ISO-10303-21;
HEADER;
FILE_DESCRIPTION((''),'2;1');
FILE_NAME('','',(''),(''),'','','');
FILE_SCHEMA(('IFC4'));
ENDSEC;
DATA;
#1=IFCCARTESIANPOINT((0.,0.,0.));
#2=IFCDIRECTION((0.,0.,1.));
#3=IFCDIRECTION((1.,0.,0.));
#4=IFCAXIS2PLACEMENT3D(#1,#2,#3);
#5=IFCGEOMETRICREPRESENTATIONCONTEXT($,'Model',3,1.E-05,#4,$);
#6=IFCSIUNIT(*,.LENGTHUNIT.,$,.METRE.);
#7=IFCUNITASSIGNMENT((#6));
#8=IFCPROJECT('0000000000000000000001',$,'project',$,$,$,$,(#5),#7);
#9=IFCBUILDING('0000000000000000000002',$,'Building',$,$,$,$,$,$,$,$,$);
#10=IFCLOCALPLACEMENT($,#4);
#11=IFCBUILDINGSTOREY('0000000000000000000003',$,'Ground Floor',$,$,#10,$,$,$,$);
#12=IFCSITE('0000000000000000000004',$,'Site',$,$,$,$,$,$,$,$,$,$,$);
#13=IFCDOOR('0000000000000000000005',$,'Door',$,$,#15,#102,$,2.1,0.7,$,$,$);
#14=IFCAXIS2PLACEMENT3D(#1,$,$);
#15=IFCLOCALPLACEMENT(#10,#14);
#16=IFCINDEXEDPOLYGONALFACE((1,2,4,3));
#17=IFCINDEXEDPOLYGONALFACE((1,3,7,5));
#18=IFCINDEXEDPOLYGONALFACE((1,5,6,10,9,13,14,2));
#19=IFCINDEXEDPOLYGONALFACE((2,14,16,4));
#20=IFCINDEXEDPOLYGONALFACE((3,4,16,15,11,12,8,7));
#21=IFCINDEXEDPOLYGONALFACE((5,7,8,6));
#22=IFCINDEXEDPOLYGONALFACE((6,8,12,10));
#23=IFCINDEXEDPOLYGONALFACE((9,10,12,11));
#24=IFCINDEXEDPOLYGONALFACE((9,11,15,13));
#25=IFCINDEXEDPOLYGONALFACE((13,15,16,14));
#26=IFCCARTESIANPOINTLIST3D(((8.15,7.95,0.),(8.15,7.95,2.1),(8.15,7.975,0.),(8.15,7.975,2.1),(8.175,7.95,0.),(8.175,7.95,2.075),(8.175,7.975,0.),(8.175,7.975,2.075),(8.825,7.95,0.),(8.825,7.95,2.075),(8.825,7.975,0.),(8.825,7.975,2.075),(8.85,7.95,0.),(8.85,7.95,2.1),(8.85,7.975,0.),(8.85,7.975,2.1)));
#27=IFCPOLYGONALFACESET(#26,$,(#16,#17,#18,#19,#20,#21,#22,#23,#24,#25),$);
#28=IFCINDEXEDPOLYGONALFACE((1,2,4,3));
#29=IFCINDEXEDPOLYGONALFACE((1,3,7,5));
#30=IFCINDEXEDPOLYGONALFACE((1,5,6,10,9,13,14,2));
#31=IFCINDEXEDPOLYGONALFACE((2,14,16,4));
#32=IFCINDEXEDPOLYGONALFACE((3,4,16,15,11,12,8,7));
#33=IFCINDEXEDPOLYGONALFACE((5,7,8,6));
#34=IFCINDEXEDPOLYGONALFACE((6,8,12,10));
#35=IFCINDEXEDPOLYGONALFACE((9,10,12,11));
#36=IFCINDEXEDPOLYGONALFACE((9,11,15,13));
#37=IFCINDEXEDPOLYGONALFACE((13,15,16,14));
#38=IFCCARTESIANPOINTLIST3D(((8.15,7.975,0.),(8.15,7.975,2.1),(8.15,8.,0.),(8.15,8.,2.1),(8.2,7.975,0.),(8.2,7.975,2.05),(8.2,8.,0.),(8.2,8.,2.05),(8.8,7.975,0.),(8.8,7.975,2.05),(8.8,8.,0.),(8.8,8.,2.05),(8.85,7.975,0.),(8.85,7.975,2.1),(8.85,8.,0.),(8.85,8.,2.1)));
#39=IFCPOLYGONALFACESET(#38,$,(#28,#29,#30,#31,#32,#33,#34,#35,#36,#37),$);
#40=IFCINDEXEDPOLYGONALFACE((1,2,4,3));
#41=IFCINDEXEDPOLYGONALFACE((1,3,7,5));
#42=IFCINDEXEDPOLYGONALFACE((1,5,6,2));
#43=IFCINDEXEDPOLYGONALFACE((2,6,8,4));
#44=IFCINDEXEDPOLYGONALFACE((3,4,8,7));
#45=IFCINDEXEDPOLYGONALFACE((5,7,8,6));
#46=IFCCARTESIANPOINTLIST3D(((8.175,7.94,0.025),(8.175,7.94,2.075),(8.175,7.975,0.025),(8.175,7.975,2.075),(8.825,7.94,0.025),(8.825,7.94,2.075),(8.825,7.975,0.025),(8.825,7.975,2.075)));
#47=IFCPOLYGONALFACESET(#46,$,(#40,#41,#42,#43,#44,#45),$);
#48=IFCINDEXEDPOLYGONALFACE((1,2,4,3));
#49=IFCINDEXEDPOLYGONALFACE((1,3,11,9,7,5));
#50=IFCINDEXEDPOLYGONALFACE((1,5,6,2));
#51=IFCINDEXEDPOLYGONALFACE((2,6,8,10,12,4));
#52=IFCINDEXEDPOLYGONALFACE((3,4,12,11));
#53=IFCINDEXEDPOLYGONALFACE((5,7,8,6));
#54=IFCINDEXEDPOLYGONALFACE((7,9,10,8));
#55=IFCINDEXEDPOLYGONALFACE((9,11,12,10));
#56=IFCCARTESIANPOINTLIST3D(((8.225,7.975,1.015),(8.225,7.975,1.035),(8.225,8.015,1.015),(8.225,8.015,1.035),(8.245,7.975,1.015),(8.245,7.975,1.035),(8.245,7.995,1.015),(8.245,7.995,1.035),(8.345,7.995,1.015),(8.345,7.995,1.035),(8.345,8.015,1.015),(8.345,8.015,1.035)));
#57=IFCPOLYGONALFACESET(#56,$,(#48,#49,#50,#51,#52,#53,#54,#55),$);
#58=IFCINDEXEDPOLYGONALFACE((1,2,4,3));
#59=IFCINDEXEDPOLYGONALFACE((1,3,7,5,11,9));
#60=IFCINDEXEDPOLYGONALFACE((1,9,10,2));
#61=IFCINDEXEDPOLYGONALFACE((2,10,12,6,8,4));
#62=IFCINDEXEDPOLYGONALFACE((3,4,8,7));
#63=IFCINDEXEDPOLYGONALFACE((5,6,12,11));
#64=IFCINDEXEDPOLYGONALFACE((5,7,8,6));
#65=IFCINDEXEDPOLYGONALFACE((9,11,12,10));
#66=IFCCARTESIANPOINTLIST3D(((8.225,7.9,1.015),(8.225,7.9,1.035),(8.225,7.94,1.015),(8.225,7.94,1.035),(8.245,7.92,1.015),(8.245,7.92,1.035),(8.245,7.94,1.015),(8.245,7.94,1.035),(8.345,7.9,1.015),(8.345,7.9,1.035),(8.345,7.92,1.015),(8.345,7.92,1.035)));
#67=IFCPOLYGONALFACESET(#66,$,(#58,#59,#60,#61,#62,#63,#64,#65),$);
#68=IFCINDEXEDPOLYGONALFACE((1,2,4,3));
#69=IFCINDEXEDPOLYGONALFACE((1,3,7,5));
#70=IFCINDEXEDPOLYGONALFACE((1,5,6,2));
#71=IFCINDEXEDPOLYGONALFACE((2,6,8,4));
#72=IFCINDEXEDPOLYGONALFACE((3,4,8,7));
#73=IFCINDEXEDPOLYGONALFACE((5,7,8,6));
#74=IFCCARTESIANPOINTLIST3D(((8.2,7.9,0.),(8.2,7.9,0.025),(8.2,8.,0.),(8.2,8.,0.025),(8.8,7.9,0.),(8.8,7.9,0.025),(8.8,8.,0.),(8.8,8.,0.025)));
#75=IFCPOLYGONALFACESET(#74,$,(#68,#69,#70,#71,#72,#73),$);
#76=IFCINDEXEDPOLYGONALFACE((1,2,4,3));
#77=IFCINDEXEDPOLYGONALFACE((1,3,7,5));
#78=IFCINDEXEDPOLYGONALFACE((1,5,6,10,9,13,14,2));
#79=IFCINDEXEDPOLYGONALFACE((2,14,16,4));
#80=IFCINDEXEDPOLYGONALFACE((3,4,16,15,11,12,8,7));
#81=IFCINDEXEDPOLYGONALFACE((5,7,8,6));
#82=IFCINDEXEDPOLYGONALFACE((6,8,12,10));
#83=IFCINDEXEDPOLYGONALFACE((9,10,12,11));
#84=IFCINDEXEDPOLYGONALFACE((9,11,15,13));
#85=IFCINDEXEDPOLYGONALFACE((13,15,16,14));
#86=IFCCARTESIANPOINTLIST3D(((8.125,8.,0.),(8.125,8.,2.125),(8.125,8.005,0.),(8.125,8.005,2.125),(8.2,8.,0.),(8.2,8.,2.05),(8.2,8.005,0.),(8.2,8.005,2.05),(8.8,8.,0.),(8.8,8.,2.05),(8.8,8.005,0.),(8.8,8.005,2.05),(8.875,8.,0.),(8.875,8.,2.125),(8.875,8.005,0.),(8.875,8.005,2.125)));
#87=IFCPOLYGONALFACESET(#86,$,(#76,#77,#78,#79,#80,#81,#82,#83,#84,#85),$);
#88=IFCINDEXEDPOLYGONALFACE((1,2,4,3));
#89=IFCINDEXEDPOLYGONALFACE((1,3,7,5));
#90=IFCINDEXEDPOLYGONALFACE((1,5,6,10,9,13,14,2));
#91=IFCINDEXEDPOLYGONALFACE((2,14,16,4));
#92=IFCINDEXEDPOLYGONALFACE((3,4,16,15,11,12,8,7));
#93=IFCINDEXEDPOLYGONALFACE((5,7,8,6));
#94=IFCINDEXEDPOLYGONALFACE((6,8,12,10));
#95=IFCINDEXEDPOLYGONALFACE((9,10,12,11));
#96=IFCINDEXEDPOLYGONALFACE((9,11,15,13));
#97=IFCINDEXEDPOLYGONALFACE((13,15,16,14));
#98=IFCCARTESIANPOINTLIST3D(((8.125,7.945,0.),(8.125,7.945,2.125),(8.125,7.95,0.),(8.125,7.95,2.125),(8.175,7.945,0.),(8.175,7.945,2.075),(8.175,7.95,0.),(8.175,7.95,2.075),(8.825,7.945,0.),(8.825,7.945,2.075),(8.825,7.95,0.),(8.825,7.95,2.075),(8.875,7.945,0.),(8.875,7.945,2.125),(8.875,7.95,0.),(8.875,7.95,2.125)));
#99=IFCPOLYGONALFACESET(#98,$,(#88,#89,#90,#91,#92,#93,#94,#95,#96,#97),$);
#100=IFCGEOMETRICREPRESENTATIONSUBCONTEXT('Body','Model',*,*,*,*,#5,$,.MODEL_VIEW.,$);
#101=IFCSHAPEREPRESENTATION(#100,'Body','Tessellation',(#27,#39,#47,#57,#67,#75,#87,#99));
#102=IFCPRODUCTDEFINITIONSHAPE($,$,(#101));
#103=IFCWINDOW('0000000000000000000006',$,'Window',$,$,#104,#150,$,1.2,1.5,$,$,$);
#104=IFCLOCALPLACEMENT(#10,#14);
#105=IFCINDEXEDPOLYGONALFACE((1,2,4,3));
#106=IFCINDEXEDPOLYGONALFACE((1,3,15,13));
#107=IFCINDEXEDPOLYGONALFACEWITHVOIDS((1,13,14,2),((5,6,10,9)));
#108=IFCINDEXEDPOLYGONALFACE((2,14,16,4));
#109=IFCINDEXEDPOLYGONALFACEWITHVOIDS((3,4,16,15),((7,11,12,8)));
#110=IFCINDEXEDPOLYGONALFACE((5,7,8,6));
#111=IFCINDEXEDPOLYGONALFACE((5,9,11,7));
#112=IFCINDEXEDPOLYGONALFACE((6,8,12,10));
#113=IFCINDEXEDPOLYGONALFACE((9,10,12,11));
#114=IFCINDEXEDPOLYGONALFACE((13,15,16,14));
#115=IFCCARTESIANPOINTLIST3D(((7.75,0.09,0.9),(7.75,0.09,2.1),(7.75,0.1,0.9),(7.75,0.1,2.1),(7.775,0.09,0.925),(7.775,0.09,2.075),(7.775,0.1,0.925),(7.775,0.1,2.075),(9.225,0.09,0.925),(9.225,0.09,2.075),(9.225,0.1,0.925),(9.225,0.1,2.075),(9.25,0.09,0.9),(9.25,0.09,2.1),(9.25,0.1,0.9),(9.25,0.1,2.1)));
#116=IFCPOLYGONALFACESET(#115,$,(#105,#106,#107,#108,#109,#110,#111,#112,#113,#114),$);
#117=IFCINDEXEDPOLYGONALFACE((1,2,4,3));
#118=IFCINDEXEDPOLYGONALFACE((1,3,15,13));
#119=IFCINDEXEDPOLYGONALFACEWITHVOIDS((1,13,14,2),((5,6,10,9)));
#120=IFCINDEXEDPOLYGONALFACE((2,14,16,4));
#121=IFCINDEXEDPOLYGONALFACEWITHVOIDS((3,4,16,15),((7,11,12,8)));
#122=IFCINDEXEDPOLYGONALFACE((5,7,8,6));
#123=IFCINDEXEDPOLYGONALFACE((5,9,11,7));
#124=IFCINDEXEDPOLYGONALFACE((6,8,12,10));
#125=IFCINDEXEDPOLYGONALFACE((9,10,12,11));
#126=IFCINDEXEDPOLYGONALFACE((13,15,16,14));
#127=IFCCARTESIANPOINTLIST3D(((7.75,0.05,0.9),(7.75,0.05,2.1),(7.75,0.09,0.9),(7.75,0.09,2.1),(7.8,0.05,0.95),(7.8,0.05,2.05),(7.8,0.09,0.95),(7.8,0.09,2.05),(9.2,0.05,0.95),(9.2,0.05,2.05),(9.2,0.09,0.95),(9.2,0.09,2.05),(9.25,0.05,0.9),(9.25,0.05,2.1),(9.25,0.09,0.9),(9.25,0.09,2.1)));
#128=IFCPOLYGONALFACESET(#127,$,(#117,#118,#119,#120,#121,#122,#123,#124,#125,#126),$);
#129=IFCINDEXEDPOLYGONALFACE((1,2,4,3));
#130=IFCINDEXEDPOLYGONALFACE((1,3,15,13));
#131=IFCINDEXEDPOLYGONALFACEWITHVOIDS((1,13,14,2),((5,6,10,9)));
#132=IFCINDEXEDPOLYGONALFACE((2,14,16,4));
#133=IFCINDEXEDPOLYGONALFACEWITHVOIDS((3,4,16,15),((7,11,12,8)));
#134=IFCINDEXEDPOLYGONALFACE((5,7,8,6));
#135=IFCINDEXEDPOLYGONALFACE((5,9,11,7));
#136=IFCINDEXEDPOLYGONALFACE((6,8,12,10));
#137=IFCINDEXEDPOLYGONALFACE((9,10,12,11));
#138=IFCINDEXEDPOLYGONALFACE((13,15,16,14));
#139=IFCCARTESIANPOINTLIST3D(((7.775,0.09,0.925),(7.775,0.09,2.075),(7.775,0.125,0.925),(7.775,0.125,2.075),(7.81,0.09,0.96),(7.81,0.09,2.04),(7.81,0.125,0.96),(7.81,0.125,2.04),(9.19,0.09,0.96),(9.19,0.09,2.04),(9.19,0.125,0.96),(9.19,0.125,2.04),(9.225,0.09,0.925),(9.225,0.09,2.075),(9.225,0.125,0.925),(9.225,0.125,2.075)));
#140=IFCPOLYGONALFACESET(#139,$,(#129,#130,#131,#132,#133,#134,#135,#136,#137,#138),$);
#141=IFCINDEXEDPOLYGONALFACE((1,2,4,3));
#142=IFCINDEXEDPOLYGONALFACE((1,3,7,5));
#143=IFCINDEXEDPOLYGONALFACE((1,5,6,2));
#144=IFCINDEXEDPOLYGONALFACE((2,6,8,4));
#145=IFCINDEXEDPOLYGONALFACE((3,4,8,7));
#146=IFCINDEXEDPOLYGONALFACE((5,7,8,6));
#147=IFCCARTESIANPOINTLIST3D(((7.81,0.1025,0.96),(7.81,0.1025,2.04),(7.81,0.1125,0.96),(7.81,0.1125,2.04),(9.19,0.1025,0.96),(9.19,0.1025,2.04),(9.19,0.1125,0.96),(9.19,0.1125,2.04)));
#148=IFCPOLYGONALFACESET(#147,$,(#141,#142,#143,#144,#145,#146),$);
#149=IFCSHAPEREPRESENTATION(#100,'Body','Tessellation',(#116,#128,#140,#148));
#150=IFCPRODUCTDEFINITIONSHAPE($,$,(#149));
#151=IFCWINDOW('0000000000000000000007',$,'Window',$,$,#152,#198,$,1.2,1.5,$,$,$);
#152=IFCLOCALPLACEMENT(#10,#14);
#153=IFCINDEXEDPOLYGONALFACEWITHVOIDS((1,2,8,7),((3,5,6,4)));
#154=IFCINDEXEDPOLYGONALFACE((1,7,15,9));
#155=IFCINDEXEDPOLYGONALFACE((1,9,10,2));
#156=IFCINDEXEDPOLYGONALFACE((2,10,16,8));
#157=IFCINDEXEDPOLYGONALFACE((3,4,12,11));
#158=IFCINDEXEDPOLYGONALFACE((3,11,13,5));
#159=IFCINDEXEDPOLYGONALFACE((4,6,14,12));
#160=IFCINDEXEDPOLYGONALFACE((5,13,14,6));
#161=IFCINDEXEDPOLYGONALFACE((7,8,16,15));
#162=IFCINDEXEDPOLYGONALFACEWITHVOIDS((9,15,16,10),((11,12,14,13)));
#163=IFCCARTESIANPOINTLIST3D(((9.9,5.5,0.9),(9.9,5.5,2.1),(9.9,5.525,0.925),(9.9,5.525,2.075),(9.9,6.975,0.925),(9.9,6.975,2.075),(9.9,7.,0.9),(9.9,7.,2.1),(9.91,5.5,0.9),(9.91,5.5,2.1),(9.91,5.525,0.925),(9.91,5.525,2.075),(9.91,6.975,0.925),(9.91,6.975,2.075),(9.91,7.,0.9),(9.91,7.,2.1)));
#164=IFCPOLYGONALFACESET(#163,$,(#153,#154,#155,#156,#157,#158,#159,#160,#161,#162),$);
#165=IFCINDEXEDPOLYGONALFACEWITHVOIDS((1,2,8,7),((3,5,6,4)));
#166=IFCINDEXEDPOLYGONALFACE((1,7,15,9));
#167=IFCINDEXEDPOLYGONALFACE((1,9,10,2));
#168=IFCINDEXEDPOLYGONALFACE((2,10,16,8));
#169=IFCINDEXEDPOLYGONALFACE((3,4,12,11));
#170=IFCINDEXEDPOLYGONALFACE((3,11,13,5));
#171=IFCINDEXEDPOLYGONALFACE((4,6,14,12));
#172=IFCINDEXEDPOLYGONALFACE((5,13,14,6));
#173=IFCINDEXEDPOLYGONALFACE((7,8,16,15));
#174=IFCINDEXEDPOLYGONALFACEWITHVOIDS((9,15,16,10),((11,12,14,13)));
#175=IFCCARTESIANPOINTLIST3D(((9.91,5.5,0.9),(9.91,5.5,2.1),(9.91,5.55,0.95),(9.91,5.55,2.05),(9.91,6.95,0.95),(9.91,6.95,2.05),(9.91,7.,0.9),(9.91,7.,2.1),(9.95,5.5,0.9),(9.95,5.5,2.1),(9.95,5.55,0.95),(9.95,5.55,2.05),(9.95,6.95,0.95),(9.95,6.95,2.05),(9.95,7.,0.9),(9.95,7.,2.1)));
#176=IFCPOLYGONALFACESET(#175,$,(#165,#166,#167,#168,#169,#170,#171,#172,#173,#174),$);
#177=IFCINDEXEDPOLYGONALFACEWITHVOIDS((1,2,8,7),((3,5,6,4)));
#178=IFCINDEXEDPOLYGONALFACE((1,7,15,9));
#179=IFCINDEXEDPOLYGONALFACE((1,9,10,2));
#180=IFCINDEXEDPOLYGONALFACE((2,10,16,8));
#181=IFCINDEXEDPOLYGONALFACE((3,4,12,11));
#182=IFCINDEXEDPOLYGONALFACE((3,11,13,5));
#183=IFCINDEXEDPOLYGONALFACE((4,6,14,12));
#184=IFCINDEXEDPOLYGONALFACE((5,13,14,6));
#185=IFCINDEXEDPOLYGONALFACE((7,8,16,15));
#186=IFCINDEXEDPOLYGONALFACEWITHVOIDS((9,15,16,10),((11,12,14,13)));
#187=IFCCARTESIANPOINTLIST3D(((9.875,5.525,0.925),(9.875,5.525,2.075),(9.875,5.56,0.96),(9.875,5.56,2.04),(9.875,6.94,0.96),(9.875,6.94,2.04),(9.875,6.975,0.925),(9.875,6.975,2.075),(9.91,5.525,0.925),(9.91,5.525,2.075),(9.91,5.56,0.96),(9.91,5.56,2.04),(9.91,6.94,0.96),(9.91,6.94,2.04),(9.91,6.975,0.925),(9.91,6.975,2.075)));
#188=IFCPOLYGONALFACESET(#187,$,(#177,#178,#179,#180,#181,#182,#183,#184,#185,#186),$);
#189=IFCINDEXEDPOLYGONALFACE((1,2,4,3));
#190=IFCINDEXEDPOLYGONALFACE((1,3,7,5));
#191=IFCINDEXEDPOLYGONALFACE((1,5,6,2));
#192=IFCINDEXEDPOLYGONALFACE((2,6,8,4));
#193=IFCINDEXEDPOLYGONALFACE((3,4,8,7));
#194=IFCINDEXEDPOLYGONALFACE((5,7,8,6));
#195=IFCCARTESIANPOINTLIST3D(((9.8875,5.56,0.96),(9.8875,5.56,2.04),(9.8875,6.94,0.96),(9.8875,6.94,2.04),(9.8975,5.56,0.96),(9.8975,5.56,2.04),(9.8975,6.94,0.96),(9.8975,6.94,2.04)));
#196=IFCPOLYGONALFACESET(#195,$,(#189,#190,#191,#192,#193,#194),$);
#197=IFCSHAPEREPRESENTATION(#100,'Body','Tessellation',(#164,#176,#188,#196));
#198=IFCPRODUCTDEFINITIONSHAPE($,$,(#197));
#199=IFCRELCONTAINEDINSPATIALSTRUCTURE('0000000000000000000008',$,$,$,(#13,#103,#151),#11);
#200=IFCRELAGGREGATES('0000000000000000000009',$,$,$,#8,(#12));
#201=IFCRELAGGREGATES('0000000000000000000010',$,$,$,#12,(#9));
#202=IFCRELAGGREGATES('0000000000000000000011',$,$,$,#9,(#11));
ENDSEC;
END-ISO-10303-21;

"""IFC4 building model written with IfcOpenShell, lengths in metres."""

from ifc_helpers import new_model, si_unit, frame, origin_with_axes, place, context, subcontext, project, spatial, line, indexed_curve, outline, extrude, element, save


model = new_model("IFC4")

# Units and contexts
model_context = context("Model", 3, precision=1e-05, world=origin_with_axes())
body_context = subcontext(model_context, "Body", "Model", "MODEL_VIEW")
ifc_project = project(units=[si_unit("LENGTHUNIT", "METRE")], contexts=[model_context])

# Site, building, storey
site = spatial("IfcSite", under=ifc_project, Name="Site")
building = spatial("IfcBuilding", under=site, Name="Building")
storey_placement = place(None, origin_with_axes())
storey = spatial("IfcBuildingStorey", under=building, at=storey_placement, Name="Ground Floor")

# Door
door_1_placement = place(storey_placement, frame((8.85, 8.0, 0.0), z_axis=(0.0, 0.0, 1.0), x_axis=(-1.0, 0.0, 0.0)))
element("IfcDoor", 1, at=door_1_placement, inside=storey, Name="Door", OverallHeight=2.1, OverallWidth=0.7, context=body_context, shape_type="SweptSolid", body=[
    extrude(outline(indexed_curve([(0.0, 0.0), (0.0, 2.1), (0.7, 2.1), (0.7, 0.0), (0.675, 0.0), (0.675, 2.075), (0.025, 2.075), (0.025, 0.0)], segments=[line(1, 2, 3, 4, 5, 6, 7, 8, 1)])), frame((0.0, 0.025, 0.0), z_axis=(0.0, -1.0, 0.0), x_axis=(1.0, 0.0, 0.0)), (0.0, 0.0, -1.0), 0.025),
    extrude(outline(indexed_curve([(0.0, 0.0), (0.0, 2.1), (0.7, 2.1), (0.7, 0.0), (0.65, 0.0), (0.65, 2.05), (0.05, 2.05), (0.05, 0.0)], segments=[line(1, 2, 3, 4, 5, 6, 7, 8, 1)])), frame((0.0, 0.0, 0.0), z_axis=(0.0, -1.0, 0.0), x_axis=(1.0, 0.0, 0.0)), (0.0, 0.0, -1.0), 0.025),
    extrude(outline(indexed_curve([(0.0, 0.0), (0.65, 0.0), (0.65, 0.035), (0.0, 0.035)], segments=[line(1, 2, 3, 4, 1)])), frame((0.025, 0.025, 0.025), z_axis=(0.0, 0.0, 1.0), x_axis=(1.0, 0.0, 0.0)), (0.0, 0.0, 1.0), 2.05),
    extrude(outline(indexed_curve([(0.0, 0.0), (0.0, -0.04), (-0.12, -0.04), (-0.12, -0.02), (-0.02, -0.02), (-0.02, 0.0)], segments=[line(1, 2, 3, 4, 5, 6, 1)])), frame((0.625, 0.025, 1.015), z_axis=(0.0, 0.0, 1.0), x_axis=(1.0, 0.0, 0.0)), (0.0, 0.0, 1.0), 0.02),
    extrude(outline(indexed_curve([(0.0, 0.0), (0.0, 0.04), (-0.12, 0.04), (-0.12, 0.02), (-0.02, 0.02), (-0.02, 0.0)], segments=[line(1, 2, 3, 4, 5, 6, 1)])), frame((0.625, 0.06, 1.015), z_axis=(0.0, 0.0, 1.0), x_axis=(1.0, 0.0, 0.0)), (0.0, 0.0, 1.0), 0.02),
    extrude(outline(indexed_curve([(0.0, 0.0), (0.6, 0.0), (0.6, 0.1), (0.0, 0.1)], segments=[line(1, 2, 3, 4, 1)])), frame((0.05, 0.0, 0.0), z_axis=(0.0, 0.0, 1.0), x_axis=(1.0, 0.0, 0.0)), (0.0, 0.0, 1.0), 0.025),
    extrude(outline(indexed_curve([(0.0, 0.0), (0.0, 2.125), (0.75, 2.125), (0.75, 0.0), (0.675, 0.0), (0.675, 2.05), (0.075, 2.05), (0.075, 0.0)], segments=[line(1, 2, 3, 4, 5, 6, 7, 8, 1)])), frame((-0.025, -0.005, 0.0), z_axis=(0.0, -1.0, 0.0), x_axis=(1.0, 0.0, 0.0)), (0.0, 0.0, -1.0), 0.005),
    extrude(outline(indexed_curve([(0.0, 0.0), (0.0, 2.125), (0.75, 2.125), (0.75, 0.0), (0.7, 0.0), (0.7, 2.075), (0.05, 2.075), (0.05, 0.0)], segments=[line(1, 2, 3, 4, 5, 6, 7, 8, 1)])), frame((-0.025, 0.05, 0.0), z_axis=(0.0, -1.0, 0.0), x_axis=(1.0, 0.0, 0.0)), (0.0, 0.0, -1.0), 0.005),
])

# Windows
for number, where, z_axis, x_axis, name in (
    (2, (7.75, 0.0, 0.9), (0.0, 0.0, 1.0), (1.0, 0.0, 0.0), "Window"),
    (3, (10.0, 5.5, 0.9), (0.0, 0.0, 1.0), (0.0, 1.0, 0.0), "Window"),
):
    element("IfcWindow", number, at=place(storey_placement, frame(where, z_axis=z_axis, x_axis=x_axis)), inside=storey, Name=name, OverallHeight=1.2, OverallWidth=1.5, context=body_context, shape_type="SweptSolid", body=[
        extrude(outline(indexed_curve([(0.0, 0.0), (1.5, 0.0), (1.5, 1.2), (0.0, 1.2)], segments=[line(1, 2, 3, 4, 1)]), holes=[indexed_curve([(0.025, 0.025), (1.475, 0.025), (1.475, 1.175), (0.025, 1.175)], segments=[line(1, 2, 3, 4, 1)])]), frame((0.0, 0.09, 0.0), z_axis=(0.0, -1.0, 0.0), x_axis=(1.0, 0.0, 0.0)), (0.0, 0.0, -1.0), 0.01),
        extrude(outline(indexed_curve([(0.0, 0.0), (1.5, 0.0), (1.5, 1.2), (0.0, 1.2)], segments=[line(1, 2, 3, 4, 1)]), holes=[indexed_curve([(0.05, 0.05), (1.45, 0.05), (1.45, 1.15), (0.05, 1.15)], segments=[line(1, 2, 3, 4, 1)])]), frame((0.0, 0.05, 0.0), z_axis=(0.0, -1.0, 0.0), x_axis=(1.0, 0.0, 0.0)), (0.0, 0.0, -1.0), 0.04),
        extrude(outline(indexed_curve([(0.0, 0.0), (1.45, 0.0), (1.45, 1.15), (0.0, 1.15)], segments=[line(1, 2, 3, 4, 1)]), holes=[indexed_curve([(0.035, 0.035), (1.415, 0.035), (1.415, 1.115), (0.035, 1.115)], segments=[line(1, 2, 3, 4, 1)])]), frame((0.025, 0.09, 0.025), z_axis=(0.0, -1.0, 0.0), x_axis=(1.0, 0.0, 0.0)), (0.0, 0.0, -1.0), 0.035),
        extrude(outline(indexed_curve([(0.035, 0.035), (1.415, 0.035), (1.415, 1.115), (0.035, 1.115)], segments=[line(1, 2, 3, 4, 1)])), frame((0.025, 0.1025, 0.025), z_axis=(0.0, -1.0, 0.0), x_axis=(1.0, 0.0, 0.0)), (0.0, 0.0, -1.0), 0.01),
    ])

save(model, "model.ifc")
